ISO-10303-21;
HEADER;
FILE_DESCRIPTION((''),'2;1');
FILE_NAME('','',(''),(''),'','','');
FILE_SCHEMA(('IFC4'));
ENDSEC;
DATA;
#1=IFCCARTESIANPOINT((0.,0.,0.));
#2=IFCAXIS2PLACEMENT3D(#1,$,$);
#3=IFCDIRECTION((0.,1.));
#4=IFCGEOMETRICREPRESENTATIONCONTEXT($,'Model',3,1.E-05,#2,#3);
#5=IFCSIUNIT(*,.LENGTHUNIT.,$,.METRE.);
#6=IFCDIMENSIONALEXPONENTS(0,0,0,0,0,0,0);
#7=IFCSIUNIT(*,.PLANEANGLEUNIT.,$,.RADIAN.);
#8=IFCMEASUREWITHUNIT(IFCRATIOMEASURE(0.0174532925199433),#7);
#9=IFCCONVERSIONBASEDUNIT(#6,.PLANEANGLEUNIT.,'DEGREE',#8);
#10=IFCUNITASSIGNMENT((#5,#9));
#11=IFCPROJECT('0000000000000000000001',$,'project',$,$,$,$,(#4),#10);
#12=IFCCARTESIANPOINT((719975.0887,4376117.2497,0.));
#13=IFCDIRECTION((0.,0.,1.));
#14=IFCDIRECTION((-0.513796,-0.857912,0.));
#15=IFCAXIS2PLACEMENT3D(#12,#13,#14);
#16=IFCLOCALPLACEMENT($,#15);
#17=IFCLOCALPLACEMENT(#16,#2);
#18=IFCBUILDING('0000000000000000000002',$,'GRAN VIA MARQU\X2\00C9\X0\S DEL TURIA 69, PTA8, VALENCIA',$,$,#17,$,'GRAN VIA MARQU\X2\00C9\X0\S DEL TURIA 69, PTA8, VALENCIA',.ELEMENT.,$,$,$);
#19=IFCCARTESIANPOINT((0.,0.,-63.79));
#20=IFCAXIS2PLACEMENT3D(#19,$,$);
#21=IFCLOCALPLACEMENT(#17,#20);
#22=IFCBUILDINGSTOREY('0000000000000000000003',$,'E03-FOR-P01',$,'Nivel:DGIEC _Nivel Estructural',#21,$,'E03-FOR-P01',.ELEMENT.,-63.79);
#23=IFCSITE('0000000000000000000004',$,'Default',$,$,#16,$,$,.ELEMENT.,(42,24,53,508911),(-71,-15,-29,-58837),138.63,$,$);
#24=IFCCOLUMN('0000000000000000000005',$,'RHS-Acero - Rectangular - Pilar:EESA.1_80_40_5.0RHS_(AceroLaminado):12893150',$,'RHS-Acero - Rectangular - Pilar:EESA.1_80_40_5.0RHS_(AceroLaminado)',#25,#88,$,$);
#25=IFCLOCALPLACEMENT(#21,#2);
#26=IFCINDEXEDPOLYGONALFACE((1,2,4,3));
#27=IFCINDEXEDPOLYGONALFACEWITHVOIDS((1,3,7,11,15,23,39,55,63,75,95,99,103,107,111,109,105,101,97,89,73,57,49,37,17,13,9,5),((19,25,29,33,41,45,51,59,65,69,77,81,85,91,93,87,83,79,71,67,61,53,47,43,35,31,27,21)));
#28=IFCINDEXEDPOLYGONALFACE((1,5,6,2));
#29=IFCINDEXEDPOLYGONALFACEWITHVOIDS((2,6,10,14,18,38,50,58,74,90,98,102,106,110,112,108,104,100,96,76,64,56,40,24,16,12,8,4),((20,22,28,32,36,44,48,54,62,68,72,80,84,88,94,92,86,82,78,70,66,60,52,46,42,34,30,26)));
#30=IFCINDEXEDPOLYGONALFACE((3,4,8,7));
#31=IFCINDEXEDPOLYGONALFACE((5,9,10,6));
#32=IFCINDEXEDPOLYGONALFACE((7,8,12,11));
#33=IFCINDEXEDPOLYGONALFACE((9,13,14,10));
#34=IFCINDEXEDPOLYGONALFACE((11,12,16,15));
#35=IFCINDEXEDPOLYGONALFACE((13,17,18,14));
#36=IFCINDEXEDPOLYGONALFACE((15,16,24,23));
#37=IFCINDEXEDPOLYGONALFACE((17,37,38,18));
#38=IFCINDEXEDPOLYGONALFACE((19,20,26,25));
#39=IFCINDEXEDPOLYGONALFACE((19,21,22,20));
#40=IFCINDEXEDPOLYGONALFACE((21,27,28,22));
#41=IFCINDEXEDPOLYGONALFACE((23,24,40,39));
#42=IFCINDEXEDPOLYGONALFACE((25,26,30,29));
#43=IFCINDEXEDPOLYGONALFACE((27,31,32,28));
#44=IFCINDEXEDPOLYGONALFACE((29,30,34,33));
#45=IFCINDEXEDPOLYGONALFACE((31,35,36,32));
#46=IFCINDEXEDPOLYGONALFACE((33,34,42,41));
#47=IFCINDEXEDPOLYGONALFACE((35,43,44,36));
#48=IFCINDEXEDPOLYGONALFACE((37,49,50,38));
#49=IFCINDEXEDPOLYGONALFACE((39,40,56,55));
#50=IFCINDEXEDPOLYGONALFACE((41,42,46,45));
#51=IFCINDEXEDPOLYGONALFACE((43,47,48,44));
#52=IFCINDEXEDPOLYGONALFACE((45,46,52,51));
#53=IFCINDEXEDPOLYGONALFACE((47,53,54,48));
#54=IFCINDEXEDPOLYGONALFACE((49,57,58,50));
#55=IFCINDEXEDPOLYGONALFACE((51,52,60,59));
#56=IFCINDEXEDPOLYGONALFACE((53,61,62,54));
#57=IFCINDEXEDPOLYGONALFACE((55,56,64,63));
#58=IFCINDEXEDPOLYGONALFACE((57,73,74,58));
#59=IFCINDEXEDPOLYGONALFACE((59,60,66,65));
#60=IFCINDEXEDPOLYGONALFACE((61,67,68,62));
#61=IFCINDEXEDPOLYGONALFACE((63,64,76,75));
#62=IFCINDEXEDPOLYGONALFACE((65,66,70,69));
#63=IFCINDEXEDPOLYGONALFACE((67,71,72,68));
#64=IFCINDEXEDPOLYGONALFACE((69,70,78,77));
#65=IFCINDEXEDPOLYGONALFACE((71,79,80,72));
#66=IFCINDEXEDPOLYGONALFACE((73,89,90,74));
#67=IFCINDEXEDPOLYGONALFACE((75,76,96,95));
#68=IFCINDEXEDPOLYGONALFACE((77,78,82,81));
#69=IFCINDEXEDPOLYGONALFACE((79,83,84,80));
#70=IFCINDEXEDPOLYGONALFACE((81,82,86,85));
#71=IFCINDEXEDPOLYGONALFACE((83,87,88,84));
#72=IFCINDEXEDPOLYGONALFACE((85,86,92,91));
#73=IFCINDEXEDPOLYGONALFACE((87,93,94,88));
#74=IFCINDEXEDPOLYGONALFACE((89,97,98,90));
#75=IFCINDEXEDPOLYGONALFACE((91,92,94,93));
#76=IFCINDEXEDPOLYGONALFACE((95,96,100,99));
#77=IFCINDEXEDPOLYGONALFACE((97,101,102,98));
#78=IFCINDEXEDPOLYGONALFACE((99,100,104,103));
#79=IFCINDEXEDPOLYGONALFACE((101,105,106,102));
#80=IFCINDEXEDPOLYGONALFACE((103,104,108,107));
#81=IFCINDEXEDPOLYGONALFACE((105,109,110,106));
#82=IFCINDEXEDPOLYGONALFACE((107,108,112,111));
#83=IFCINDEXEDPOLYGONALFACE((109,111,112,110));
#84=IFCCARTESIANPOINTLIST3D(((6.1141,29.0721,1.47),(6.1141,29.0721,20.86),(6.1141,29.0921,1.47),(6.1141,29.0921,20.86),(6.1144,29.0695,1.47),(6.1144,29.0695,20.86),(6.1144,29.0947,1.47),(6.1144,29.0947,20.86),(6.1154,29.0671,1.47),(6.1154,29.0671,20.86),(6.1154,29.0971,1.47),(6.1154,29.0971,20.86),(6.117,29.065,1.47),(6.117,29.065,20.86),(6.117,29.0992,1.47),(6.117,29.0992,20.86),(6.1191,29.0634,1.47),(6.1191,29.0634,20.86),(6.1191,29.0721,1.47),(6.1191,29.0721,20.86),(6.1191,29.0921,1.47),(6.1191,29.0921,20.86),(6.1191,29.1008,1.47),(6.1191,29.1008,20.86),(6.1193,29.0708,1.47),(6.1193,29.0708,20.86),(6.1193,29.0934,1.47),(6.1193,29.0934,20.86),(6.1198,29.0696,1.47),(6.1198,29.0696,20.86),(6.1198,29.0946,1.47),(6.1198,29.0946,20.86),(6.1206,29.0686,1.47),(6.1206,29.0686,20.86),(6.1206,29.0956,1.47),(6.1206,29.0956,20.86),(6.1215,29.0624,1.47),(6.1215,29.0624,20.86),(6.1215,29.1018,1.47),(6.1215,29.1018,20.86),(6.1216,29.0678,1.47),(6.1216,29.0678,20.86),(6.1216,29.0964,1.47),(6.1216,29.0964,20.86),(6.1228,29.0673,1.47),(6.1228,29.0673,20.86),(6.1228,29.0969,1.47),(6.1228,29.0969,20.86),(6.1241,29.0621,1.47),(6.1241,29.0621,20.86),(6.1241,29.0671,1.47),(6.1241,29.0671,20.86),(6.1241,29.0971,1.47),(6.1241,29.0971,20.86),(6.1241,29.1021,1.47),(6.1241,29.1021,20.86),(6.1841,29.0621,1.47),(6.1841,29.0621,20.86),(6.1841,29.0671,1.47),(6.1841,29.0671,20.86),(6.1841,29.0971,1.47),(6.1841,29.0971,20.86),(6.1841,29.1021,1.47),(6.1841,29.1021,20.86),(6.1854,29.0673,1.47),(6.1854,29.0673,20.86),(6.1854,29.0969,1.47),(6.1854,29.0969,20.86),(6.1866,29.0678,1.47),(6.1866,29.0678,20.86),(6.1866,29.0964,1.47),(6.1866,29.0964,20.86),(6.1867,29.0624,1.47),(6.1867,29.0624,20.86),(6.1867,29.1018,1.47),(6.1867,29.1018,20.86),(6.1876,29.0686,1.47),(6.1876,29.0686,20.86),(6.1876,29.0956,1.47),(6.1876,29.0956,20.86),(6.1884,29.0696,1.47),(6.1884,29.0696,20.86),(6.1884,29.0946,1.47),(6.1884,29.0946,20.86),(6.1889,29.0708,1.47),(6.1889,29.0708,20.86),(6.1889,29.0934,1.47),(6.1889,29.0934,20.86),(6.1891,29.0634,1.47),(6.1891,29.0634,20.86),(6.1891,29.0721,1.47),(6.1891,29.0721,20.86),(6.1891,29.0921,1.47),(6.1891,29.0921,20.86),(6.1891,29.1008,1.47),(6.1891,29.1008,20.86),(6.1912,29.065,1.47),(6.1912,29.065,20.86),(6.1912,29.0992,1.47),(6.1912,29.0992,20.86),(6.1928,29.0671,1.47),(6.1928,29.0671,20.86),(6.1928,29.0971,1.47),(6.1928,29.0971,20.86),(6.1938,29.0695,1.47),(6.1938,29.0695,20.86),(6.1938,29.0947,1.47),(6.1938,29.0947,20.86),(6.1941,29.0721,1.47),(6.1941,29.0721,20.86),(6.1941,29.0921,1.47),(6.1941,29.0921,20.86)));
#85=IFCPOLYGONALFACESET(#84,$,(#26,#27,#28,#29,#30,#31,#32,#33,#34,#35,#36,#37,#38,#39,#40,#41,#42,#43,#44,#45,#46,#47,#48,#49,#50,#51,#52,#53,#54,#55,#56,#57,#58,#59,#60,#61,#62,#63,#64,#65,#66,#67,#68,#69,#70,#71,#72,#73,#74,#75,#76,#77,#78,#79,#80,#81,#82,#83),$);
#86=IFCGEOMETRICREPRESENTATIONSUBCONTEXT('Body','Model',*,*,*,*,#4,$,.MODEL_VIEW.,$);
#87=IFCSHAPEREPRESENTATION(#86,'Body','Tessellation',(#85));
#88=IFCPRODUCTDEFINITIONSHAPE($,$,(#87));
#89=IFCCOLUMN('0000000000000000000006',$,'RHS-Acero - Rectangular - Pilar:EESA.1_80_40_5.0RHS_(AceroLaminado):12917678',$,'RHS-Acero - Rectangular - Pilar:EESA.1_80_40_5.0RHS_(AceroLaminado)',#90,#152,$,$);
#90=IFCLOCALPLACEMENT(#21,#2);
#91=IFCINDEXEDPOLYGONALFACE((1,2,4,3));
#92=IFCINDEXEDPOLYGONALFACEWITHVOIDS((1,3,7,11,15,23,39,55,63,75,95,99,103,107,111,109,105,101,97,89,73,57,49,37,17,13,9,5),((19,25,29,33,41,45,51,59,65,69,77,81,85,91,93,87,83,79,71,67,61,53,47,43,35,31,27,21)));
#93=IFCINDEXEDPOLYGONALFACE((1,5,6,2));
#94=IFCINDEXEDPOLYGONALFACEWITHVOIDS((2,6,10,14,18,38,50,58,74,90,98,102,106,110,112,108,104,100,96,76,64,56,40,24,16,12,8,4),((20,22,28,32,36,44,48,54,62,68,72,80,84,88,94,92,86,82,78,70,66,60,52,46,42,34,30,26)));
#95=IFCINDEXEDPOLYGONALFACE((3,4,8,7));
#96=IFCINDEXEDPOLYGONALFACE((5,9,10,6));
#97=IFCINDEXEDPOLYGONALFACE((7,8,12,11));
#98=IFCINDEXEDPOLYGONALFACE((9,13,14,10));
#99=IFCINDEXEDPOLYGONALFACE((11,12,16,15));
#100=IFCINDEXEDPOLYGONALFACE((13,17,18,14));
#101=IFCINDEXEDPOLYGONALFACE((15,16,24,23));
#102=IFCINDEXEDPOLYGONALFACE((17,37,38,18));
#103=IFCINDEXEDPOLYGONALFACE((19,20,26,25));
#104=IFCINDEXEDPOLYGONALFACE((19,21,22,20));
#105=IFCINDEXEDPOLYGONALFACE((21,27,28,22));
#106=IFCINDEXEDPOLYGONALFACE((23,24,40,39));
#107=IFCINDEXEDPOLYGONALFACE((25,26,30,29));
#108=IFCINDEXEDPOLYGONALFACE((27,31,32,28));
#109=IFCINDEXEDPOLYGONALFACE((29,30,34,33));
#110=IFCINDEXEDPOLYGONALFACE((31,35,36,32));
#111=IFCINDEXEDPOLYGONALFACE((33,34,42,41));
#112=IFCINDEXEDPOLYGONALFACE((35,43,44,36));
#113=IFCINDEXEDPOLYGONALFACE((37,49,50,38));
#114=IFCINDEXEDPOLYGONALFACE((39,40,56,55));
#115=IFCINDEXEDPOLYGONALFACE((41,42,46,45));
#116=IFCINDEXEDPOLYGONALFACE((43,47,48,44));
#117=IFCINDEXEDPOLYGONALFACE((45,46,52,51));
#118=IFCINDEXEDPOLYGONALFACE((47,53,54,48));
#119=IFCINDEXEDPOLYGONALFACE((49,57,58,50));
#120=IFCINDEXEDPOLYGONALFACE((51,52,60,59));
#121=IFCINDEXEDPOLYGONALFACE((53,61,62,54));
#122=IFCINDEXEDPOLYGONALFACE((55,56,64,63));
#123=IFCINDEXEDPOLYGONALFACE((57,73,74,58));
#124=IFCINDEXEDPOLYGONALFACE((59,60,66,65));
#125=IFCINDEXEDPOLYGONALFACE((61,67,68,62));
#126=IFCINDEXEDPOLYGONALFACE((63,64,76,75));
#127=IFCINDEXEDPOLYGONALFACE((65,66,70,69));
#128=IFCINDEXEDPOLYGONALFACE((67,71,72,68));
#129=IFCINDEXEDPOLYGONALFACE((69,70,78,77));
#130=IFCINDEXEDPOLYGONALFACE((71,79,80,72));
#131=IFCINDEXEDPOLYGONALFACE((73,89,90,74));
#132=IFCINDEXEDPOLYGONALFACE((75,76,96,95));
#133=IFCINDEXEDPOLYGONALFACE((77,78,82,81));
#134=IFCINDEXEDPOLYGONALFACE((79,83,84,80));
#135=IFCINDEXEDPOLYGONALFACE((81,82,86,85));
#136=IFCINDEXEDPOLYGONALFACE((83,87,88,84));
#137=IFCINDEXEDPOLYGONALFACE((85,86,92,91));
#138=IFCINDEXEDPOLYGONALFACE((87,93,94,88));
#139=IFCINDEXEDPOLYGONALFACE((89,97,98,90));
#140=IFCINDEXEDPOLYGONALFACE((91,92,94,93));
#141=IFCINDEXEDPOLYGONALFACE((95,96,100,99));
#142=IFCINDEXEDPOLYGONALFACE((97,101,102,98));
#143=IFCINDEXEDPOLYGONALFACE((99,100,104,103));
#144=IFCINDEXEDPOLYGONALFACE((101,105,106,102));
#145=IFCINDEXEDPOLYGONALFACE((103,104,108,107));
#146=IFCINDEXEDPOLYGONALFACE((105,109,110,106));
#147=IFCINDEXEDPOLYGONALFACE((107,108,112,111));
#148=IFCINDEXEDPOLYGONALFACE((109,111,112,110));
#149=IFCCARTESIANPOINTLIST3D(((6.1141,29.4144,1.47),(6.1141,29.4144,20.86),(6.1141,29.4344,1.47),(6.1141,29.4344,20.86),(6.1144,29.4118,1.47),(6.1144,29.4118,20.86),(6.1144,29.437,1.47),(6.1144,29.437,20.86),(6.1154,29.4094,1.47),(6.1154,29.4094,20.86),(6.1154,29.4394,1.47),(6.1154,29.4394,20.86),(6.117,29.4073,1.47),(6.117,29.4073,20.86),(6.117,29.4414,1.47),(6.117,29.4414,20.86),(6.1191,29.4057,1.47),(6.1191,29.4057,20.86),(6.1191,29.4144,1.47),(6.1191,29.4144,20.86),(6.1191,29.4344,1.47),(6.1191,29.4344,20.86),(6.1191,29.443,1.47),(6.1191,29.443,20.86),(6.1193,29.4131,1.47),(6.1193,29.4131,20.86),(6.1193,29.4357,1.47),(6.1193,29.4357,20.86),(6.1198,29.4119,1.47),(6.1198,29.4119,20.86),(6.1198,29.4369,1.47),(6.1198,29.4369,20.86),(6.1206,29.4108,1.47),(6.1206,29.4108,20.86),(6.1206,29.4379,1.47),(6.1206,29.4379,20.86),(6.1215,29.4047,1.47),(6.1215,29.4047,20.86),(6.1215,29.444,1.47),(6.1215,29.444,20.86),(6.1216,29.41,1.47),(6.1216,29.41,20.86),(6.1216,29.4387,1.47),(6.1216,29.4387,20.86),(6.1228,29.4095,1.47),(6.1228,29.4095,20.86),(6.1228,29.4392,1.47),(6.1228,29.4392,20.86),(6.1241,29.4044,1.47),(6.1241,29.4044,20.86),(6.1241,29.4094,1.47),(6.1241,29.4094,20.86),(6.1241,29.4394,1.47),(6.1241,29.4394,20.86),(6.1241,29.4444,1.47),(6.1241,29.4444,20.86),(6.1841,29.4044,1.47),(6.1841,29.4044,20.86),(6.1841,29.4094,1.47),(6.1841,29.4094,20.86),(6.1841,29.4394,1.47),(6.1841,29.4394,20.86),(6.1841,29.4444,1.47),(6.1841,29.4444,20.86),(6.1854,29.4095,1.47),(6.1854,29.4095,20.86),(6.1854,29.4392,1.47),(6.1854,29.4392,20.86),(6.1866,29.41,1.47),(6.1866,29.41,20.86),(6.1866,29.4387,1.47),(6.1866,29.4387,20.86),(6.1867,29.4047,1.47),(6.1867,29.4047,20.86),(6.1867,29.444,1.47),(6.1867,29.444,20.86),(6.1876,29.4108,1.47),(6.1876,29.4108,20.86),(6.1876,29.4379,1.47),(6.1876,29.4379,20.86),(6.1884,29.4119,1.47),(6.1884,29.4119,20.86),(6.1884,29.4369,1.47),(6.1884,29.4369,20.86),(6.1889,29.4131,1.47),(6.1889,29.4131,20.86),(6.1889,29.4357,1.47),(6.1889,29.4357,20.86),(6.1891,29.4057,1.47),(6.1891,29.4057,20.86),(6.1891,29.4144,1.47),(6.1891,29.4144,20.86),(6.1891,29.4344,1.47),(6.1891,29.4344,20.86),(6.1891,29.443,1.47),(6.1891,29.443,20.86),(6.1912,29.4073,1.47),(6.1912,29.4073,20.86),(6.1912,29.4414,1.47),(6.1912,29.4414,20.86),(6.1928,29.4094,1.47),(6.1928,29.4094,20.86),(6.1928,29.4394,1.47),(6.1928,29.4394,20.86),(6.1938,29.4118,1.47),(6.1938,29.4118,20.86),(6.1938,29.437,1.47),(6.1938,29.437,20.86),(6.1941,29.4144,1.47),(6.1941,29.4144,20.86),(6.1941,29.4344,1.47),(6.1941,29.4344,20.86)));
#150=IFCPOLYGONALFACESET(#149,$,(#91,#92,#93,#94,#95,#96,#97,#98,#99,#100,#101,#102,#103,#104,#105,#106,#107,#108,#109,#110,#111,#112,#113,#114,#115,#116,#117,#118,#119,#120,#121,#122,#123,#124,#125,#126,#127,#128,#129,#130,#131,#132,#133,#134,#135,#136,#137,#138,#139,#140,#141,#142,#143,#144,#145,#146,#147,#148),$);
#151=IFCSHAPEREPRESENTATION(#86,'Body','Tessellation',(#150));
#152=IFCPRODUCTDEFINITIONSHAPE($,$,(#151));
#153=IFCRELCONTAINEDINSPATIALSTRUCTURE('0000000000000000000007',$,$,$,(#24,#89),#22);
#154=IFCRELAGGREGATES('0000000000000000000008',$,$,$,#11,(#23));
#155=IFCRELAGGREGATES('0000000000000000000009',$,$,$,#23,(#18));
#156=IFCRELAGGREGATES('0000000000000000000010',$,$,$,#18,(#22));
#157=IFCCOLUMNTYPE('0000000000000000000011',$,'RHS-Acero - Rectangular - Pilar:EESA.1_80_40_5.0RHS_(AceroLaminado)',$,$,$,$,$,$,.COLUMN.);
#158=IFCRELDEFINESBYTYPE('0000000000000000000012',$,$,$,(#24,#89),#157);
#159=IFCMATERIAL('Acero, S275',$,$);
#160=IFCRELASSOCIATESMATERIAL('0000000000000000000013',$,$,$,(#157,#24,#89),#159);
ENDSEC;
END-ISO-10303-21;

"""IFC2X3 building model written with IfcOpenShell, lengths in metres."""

from ifc_helpers import new_model, entity, si_unit, converted_unit, direction, frame, frame_2d, origin, place, context, subcontext, project, spatial, polyline, circle_curve, parameter, trimmed, segment, composite_curve, outline, extrude, source, transform, mapped, material, type_object, type_shapes, element, save


model = new_model("IFC2X3")

# Units and contexts
model_context = context("Model", 3, precision=1e-05, world=origin(), true_north=direction((0.0, 1.0)))
body_context = subcontext(model_context, "Body", "Model", "MODEL_VIEW")
ifc_project = project(units=[si_unit("LENGTHUNIT", "METRE"), converted_unit("PLANEANGLEUNIT", "DEGREE", entity("IfcRatioMeasure", 0.0174532925199433), si_unit("PLANEANGLEUNIT", "RADIAN"), dimensions=[0, 0, 0, 0, 0, 0, 0])], contexts=[model_context])

# Site, building, storey
site_placement = place(None, frame((719975.0887, 4376117.2497, 0.0), z_axis=(0.0, 0.0, 1.0), x_axis=(-0.513796, -0.857912, 0.0)))
site = spatial("IfcSite", under=ifc_project, at=site_placement, Name="Default", CompositionType="ELEMENT", RefLatitude=(42, 24, 53, 508911), RefLongitude=(-71, -15, -29, -58837), RefElevation=138.63)
building_placement = place(site_placement, origin())
building = spatial("IfcBuilding", under=site, at=building_placement, Name="GRAN VIA MARQUÉS DEL TURIA 69, PTA8, VALENCIA", LongName="GRAN VIA MARQUÉS DEL TURIA 69, PTA8, VALENCIA", CompositionType="ELEMENT")
storey_placement = place(building_placement, frame((0.0, 0.0, -63.79)))
storey = spatial("IfcBuildingStorey", under=building, at=storey_placement, Name="E03-FOR-P01", ObjectType="Nivel:DGIEC _Nivel Estructural", LongName="E03-FOR-P01", CompositionType="ELEMENT", Elevation=-63.79)

# Columns
ifc_material_1 = material(Name="Acero, S275")
column_type_1 = type_object("IfcColumnType", Name="RHS-Acero - Rectangular - Pilar:EESA.1_80_40_5.0RHS_(AceroLaminado)", PredefinedType="COLUMN", material=ifc_material_1)
shared_shape_1 = source(origin(), body_context, "Body", "SweptSolid", [
    extrude(outline(composite_curve([segment(polyline([(-0.01, -0.04), (0.01, -0.04)]), True, "CONTINUOUS"), segment(trimmed(circle_curve(frame_2d((0.01, -0.03), x_axis=(-1.0, 0.0)), 0.01), [parameter(90.0)], [parameter(180.0)], True, "PARAMETER"), True, "CONTINUOUS"), segment(polyline([(0.02, -0.03), (0.02, 0.03)]), True, "CONTINUOUS"), segment(trimmed(circle_curve(frame_2d((0.01, 0.03), x_axis=(-1.0, 0.0)), 0.01), [parameter(180.0)], [parameter(270.0)], True, "PARAMETER"), True, "CONTINUOUS"), segment(polyline([(0.01, 0.04), (-0.01, 0.04)]), True, "CONTINUOUS"), segment(trimmed(circle_curve(frame_2d((-0.01, 0.03), x_axis=(-1.0, 0.0)), 0.01), [parameter(270.0)], [parameter(360.0)], True, "PARAMETER"), True, "CONTINUOUS"), segment(polyline([(-0.02, 0.03), (-0.02, -0.03)]), True, "CONTINUOUS"), segment(trimmed(circle_curve(frame_2d((-0.01, -0.03), x_axis=(-1.0, 0.0)), 0.01), [parameter(360.0)], [parameter(90.0)], True, "PARAMETER"), True, "CONTINUOUS")], self_intersect=False), holes=[composite_curve([segment(trimmed(circle_curve(frame_2d((-0.01, -0.03), x_axis=(-1.0, 0.0)), 0.005), [parameter(0.0)], [parameter(90.0)], True, "PARAMETER"), False, "CONTINUOUS"), segment(polyline([(-0.015, -0.03), (-0.015, 0.03)]), True, "CONTINUOUS"), segment(trimmed(circle_curve(frame_2d((-0.01, 0.03), x_axis=(-1.0, 0.0)), 0.005), [parameter(270.0)], [parameter(0.0)], True, "PARAMETER"), False, "CONTINUOUS"), segment(polyline([(-0.01, 0.035), (0.01, 0.035)]), True, "CONTINUOUS"), segment(trimmed(circle_curve(frame_2d((0.01, 0.03), x_axis=(-1.0, 0.0)), 0.005), [parameter(180.0)], [parameter(270.0)], True, "PARAMETER"), False, "CONTINUOUS"), segment(polyline([(0.015, 0.03), (0.015, -0.03)]), True, "CONTINUOUS"), segment(trimmed(circle_curve(frame_2d((0.01, -0.03), x_axis=(-1.0, 0.0)), 0.005), [parameter(90.0)], [parameter(180.0)], True, "PARAMETER"), False, "CONTINUOUS"), segment(polyline([(0.01, -0.035), (-0.01, -0.035)]), True, "CONTINUOUS")], self_intersect=False)]), frame((0.0, 0.0, -62.32), z_axis=(0.0, 0.0, 1.0), x_axis=(-1.0, 0.0, 0.0)), (0.0, 0.0, 1.0), 19.39),
])
type_shapes(column_type_1, [shared_shape_1])
for number, where, z_axis, x_axis, name in (
    (1, (6.1541, 29.0821, 63.79), (0.0, 0.0, 1.0), (0.0, 1.0, 0.0), "RHS-Acero - Rectangular - Pilar:EESA.1_80_40_5.0RHS_(AceroLaminado):12893150"),
    (2, (6.1541, 29.4244, 63.79), (0.0, 0.0, 1.0), (0.0, 1.0, 0.0), "RHS-Acero - Rectangular - Pilar:EESA.1_80_40_5.0RHS_(AceroLaminado):12917678"),
):
    element("IfcColumn", number, at=place(storey_placement, frame(where, z_axis=z_axis, x_axis=x_axis)), inside=storey, type_object=column_type_1, material=ifc_material_1, Name=name, ObjectType="RHS-Acero - Rectangular - Pilar:EESA.1_80_40_5.0RHS_(AceroLaminado)", context=body_context, shape_type="MappedRepresentation", body=[
        mapped(shared_shape_1, transform((0.0, 0.0, 0.0), scale=1.0)),
    ])

save(model, "model.ifc")
